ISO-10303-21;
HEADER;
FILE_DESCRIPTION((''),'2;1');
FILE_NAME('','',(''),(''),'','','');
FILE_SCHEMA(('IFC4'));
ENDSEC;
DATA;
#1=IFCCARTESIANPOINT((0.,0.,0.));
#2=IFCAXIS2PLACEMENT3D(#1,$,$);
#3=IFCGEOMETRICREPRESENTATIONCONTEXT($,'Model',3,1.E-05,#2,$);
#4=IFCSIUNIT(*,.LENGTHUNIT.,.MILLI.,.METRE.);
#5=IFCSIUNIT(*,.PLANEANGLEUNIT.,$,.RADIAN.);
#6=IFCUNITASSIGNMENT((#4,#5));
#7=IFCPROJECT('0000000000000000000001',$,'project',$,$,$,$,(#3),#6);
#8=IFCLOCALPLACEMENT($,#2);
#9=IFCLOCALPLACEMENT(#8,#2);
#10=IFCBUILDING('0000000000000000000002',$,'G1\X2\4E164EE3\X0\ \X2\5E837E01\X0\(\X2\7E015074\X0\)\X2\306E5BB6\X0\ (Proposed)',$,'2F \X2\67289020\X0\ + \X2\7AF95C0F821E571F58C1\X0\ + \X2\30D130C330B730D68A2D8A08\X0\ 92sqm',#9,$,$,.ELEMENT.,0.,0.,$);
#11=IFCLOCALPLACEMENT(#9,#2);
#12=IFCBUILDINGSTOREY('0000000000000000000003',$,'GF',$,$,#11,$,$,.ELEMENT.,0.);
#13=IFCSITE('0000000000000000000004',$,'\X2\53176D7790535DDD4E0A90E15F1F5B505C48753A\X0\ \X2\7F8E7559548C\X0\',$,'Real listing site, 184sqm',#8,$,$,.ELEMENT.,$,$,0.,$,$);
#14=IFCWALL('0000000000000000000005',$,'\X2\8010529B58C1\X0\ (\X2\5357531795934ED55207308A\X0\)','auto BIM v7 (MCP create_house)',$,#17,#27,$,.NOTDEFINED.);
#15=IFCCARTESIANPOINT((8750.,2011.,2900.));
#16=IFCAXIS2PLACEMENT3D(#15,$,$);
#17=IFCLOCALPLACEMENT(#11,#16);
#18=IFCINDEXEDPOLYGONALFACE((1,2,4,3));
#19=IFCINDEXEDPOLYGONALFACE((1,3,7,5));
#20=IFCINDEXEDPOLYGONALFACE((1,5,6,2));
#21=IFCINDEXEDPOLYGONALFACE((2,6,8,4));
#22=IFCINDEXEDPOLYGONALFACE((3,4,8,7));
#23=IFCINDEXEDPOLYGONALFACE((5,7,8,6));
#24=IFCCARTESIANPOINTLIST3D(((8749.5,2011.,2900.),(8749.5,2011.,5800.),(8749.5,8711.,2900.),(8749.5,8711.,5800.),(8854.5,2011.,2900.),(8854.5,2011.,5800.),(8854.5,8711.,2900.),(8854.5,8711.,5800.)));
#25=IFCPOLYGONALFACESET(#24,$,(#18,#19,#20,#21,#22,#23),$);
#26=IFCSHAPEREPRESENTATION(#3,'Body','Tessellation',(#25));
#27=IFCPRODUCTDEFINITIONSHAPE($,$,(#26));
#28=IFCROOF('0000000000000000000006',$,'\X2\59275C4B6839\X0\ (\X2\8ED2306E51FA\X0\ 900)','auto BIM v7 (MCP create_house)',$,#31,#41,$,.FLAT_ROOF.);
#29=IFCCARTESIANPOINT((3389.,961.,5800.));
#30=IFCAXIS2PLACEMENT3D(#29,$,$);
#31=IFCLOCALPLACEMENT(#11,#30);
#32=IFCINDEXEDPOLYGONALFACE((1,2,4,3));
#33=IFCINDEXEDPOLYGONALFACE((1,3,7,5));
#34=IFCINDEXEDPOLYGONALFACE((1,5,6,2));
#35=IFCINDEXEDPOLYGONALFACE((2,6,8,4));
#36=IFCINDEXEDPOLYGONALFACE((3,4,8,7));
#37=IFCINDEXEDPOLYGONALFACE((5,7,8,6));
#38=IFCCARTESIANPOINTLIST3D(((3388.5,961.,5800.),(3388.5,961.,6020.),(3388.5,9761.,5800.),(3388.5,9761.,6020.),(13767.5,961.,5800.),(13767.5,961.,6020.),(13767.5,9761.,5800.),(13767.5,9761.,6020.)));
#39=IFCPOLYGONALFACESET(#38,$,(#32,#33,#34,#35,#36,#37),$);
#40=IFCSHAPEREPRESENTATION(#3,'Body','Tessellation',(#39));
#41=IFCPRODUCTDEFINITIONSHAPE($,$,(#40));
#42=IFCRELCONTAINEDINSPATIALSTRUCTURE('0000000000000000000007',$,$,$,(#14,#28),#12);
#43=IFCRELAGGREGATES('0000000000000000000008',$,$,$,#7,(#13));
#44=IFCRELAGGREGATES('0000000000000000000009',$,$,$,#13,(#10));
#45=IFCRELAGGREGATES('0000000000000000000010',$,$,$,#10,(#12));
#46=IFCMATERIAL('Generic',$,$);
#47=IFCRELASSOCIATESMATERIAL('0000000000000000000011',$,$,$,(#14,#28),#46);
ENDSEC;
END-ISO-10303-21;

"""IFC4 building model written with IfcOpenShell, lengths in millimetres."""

from ifc_helpers import new_model, si_unit, frame, frame_2d, origin, place, context, project, spatial, rectangle, extrude, material, element, save


model = new_model("IFC4")

# Units and contexts
model_context = context("Model", 3, precision=1e-05, world=origin())
ifc_project = project(units=[si_unit("LENGTHUNIT", "METRE", prefix="MILLI"), si_unit("PLANEANGLEUNIT", "RADIAN")], contexts=[model_context])

# Site, building, storey
site_placement = place(None, origin())
site = spatial("IfcSite", under=ifc_project, at=site_placement, Name="北海道川上郡弟子屈町 美留和", ObjectType="Real listing site, 184sqm", CompositionType="ELEMENT", RefElevation=0.0)
building_placement = place(site_placement, origin())
building = spatial("IfcBuilding", under=site, at=building_placement, Name="G1世代 広縁(縁側)の家 (Proposed)", ObjectType="2F 木造 + 竹小舞土壁 + パッシブ設計 92sqm", CompositionType="ELEMENT", ElevationOfRefHeight=0.0, ElevationOfTerrain=0.0)
storey_placement = place(building_placement, origin())
storey = spatial("IfcBuildingStorey", under=building, at=storey_placement, Name="GF", CompositionType="ELEMENT", Elevation=0.0)

# Shared definitions
ifc_material = material(Name="Generic")

# Wall
wall_1_placement = place(storey_placement, frame((8750.0, 2011.0, 2900.0)))
element("IfcWall", 1, at=wall_1_placement, inside=storey, material=ifc_material, Name="耐力壁 (南北間仕切り)", Description="auto BIM v7 (MCP create_house)", PredefinedType="NOTDEFINED", context=model_context, shape_type="SweptSolid", body=[
    extrude(rectangle(XDim=105.0, YDim=6700.0, at=frame_2d((52.0, 3350.0))), frame((8750.0, 2011.0, 2900.0)), (0.0, 0.0, 1.0), 2900.0),
])

# Roof
roof_placement = place(storey_placement, frame((3389.0, 961.0, 5800.0)))
element("IfcRoof", 2, at=roof_placement, inside=storey, material=ifc_material, Name="大屋根 (軒の出 900)", Description="auto BIM v7 (MCP create_house)", PredefinedType="FLAT_ROOF", context=model_context, shape_type="SweptSolid", body=[
    extrude(rectangle(XDim=10379.0, YDim=8800.0, at=frame_2d((5189.0, 4400.0))), frame((3389.0, 961.0, 5800.0)), (0.0, 0.0, 1.0), 220.0),
])

save(model, "model.ifc")
